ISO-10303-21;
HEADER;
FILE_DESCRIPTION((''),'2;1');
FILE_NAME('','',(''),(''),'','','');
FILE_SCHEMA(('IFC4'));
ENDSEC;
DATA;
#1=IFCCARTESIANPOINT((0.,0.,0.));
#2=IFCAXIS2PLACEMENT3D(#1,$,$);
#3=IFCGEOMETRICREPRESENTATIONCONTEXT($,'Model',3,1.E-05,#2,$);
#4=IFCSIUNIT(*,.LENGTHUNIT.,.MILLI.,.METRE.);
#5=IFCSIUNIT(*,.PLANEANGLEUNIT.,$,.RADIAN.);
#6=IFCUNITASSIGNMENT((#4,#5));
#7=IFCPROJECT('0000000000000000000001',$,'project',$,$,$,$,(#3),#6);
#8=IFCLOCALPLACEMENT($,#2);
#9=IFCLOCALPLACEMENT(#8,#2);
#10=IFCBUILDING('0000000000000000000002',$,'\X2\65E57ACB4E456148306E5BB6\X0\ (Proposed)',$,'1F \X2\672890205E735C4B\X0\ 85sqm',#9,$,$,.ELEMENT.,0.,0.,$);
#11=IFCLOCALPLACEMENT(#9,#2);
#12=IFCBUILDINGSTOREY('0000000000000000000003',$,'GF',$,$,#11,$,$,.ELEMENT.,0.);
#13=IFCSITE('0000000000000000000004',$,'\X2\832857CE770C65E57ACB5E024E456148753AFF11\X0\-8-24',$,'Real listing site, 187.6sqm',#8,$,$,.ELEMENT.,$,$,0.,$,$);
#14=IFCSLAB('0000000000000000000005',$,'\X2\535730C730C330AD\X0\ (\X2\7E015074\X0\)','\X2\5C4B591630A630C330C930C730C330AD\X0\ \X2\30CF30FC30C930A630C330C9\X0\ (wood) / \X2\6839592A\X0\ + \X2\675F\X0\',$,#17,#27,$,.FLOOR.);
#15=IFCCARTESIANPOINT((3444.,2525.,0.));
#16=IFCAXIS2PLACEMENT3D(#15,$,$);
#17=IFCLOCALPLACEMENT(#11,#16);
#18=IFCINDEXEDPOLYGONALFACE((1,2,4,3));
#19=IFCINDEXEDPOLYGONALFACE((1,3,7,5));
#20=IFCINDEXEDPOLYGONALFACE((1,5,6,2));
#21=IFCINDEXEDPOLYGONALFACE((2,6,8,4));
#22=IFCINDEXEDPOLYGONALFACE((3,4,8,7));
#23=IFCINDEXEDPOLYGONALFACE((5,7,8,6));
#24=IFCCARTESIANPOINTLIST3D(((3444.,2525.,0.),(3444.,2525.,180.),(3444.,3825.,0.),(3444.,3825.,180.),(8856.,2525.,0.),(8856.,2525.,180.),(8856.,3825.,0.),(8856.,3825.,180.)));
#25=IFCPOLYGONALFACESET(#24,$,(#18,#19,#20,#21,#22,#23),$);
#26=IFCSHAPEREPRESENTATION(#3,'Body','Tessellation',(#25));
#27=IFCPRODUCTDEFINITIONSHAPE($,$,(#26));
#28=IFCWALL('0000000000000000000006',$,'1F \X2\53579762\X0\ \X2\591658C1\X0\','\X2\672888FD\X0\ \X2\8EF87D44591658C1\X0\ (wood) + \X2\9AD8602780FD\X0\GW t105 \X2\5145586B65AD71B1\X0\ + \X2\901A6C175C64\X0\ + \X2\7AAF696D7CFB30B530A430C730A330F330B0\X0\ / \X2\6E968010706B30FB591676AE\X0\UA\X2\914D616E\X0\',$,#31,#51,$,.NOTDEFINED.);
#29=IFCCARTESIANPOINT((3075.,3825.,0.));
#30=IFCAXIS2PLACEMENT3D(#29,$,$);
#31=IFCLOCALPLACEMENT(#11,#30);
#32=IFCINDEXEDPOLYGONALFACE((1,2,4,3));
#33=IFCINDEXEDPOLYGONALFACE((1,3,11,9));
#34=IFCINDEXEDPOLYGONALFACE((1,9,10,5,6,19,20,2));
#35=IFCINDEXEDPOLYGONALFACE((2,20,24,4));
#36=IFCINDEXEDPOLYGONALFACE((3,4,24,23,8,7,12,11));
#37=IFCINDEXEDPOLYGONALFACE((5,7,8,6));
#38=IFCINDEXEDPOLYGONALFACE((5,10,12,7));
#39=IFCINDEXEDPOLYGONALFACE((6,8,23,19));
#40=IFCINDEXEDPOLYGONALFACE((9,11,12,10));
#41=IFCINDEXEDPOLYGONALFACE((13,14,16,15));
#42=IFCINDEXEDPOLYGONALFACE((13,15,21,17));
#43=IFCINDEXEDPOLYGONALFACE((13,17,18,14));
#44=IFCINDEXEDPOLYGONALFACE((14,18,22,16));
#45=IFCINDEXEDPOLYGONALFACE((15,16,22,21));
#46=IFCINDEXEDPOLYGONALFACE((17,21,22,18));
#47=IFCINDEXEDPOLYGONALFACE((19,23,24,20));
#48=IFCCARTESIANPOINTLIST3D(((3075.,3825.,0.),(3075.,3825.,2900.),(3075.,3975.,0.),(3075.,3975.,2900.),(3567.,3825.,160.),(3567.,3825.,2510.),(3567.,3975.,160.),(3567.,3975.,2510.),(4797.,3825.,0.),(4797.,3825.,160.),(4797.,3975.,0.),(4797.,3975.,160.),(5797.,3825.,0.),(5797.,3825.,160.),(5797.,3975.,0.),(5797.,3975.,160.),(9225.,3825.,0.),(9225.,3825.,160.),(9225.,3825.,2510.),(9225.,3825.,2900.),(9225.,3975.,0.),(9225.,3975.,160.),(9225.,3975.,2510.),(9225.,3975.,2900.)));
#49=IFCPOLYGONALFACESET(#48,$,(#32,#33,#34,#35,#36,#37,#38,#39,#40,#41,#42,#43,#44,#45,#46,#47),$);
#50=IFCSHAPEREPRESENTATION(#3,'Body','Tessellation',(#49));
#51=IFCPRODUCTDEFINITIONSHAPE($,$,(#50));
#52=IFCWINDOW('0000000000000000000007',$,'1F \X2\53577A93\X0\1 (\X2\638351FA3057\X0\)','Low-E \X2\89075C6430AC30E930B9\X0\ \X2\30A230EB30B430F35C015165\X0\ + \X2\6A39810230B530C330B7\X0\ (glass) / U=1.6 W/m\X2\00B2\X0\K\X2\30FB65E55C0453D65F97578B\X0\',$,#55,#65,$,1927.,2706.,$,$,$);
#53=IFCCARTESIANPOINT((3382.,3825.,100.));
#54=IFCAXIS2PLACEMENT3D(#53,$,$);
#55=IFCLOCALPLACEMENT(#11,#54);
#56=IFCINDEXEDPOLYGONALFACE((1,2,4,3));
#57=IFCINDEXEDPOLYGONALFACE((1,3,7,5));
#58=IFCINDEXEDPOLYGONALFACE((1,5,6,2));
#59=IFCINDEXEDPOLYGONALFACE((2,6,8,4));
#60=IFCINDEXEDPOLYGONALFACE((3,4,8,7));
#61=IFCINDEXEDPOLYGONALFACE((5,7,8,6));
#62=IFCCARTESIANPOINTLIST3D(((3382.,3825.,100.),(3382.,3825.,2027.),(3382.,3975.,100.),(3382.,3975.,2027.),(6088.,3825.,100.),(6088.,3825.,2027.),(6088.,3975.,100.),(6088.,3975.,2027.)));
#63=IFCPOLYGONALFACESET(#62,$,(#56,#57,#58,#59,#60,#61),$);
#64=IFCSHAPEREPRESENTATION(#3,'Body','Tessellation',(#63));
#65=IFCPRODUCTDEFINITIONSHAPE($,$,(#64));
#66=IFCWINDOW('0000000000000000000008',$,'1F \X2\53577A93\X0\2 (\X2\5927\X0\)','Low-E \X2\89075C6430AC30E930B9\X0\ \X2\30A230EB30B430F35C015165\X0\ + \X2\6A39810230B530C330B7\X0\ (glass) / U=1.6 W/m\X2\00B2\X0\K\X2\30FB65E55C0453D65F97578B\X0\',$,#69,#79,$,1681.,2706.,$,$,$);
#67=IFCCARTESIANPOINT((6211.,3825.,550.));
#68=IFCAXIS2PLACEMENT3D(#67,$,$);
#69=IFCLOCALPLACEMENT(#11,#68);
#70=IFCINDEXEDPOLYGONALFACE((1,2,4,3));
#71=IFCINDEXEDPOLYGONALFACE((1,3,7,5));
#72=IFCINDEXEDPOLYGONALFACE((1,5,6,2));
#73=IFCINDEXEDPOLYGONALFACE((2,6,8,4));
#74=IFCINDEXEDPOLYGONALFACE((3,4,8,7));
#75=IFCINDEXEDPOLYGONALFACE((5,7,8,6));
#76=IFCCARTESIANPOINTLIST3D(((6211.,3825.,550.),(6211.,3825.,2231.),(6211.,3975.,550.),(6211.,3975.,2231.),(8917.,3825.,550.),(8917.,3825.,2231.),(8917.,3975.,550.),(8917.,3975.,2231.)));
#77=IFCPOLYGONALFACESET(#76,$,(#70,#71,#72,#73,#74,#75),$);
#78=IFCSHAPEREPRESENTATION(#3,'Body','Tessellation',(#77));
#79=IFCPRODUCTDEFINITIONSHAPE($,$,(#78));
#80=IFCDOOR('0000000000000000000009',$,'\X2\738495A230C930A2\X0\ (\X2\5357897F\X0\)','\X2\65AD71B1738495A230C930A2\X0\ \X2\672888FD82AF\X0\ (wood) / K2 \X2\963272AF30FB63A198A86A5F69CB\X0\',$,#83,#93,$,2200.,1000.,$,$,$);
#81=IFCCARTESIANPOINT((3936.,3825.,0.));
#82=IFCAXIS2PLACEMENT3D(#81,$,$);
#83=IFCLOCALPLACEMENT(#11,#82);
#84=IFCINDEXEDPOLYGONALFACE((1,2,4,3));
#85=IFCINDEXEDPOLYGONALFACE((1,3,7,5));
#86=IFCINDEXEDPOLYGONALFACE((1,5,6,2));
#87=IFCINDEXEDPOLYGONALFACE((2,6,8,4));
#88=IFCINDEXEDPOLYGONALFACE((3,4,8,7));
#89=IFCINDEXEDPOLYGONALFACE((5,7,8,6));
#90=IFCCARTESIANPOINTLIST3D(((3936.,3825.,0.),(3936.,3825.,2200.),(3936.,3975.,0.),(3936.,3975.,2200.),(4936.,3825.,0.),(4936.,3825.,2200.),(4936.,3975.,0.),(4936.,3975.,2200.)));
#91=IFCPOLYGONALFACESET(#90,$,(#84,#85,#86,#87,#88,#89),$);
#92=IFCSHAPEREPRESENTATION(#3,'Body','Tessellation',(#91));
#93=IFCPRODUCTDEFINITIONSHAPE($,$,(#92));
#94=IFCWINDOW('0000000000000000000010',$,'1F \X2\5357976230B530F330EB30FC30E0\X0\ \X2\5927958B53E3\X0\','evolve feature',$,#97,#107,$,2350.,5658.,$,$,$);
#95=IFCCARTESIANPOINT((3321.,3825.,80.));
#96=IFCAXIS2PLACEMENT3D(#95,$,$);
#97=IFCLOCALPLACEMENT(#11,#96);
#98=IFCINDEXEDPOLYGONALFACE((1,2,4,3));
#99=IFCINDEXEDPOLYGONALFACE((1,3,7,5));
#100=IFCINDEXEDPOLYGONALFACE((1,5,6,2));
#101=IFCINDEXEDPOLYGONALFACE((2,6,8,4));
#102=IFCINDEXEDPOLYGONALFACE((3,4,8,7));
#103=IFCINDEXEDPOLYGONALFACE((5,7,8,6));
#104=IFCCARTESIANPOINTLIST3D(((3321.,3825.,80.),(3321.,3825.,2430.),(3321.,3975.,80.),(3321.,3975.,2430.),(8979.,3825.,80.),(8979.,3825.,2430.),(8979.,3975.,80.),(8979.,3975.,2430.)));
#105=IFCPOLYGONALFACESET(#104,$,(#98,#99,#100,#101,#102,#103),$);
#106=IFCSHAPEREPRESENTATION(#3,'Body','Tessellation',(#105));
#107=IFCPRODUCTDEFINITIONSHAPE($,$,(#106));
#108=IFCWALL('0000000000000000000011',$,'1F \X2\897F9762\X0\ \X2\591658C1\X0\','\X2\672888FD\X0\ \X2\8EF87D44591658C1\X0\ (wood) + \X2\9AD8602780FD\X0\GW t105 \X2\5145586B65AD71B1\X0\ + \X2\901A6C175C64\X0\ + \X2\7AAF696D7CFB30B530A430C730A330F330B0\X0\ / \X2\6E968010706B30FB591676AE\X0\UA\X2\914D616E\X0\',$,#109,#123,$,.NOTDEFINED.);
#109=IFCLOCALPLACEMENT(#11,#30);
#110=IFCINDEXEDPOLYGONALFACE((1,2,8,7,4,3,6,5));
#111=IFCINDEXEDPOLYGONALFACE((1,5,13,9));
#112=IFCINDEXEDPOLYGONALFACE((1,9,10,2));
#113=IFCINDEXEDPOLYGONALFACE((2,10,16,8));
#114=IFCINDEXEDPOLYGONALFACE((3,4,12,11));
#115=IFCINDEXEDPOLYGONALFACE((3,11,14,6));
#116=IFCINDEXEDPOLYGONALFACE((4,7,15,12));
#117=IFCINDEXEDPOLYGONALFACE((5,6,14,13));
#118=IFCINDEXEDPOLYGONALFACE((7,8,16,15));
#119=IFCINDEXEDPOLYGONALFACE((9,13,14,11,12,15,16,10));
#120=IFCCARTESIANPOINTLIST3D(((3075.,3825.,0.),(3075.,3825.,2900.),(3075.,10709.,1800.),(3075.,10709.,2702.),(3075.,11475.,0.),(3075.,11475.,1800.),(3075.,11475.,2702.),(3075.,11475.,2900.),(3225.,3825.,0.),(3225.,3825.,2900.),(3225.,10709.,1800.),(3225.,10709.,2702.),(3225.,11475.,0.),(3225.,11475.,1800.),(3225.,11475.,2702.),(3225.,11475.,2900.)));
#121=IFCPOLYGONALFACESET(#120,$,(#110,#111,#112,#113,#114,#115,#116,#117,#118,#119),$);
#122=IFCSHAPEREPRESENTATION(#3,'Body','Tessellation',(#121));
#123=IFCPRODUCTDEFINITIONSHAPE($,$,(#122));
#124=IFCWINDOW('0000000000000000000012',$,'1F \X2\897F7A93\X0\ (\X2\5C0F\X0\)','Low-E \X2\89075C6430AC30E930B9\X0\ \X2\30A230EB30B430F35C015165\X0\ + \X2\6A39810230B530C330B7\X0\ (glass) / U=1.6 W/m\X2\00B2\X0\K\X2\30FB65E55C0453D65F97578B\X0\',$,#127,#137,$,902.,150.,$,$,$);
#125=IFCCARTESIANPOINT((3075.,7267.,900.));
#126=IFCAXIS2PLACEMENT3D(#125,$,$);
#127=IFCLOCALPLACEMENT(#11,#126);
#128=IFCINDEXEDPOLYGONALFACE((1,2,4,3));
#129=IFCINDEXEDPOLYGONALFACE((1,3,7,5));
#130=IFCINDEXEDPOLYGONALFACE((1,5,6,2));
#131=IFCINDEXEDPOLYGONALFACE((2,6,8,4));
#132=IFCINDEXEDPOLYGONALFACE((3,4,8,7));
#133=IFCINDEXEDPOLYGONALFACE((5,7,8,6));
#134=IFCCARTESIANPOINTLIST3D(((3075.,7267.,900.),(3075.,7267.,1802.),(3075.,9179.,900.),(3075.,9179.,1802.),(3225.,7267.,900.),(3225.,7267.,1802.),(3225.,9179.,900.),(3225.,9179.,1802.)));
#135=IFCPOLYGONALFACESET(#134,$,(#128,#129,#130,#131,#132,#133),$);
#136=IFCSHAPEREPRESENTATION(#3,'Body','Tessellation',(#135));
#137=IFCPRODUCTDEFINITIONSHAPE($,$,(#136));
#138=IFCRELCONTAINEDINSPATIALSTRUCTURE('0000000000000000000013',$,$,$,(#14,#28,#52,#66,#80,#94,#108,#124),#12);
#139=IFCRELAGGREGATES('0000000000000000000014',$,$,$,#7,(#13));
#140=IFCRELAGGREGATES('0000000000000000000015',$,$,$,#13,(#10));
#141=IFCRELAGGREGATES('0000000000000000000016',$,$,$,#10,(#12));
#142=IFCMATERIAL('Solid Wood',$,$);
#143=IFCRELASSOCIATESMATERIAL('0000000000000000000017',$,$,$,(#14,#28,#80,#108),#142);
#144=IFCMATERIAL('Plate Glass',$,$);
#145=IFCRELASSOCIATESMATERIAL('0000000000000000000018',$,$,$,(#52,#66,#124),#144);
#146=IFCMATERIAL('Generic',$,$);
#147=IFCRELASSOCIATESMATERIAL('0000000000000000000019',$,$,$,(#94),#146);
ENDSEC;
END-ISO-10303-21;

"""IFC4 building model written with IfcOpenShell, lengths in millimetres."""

from ifc_helpers import new_model, si_unit, frame, frame_2d, origin, place, context, project, spatial, rectangle, extrude, material, element, fill, save


model = new_model("IFC4")

# Units and contexts
model_context = context("Model", 3, precision=1e-05, world=origin())
ifc_project = project(units=[si_unit("LENGTHUNIT", "METRE", prefix="MILLI"), si_unit("PLANEANGLEUNIT", "RADIAN")], contexts=[model_context])

# Site, building, storey
site_placement = place(None, origin())
site = spatial("IfcSite", under=ifc_project, at=site_placement, Name="茨城県日立市久慈町１-8-24", ObjectType="Real listing site, 187.6sqm", CompositionType="ELEMENT", RefElevation=0.0)
building_placement = place(site_placement, origin())
building = spatial("IfcBuilding", under=site, at=building_placement, Name="日立久慈の家 (Proposed)", ObjectType="1F 木造平屋 85sqm", CompositionType="ELEMENT", ElevationOfRefHeight=0.0, ElevationOfTerrain=0.0)
storey_placement = place(building_placement, origin())
storey = spatial("IfcBuildingStorey", under=building, at=storey_placement, Name="GF", CompositionType="ELEMENT", Elevation=0.0)

# Slab
ifc_material_1 = material(Name="Solid Wood")
slab_1_placement = place(storey_placement, frame((3444.0, 2525.0, 0.0)))
element("IfcSlab", 1, at=slab_1_placement, inside=storey, material=ifc_material_1, Name="南デッキ (縁側)", Description="屋外ウッドデッキ ハードウッド (wood) / 根太 + 束", PredefinedType="FLOOR", context=model_context, shape_type="SweptSolid", body=[
    extrude(rectangle(XDim=5412.0, YDim=1300.0, at=frame_2d((2706.0, 650.0))), frame((3444.0, 2525.0, 0.0)), (0.0, 0.0, 1.0), 180.0),
])
ifc_material_2 = material(Name="Generic")

# Wall, openings, windows, door
wall_1_placement = place(storey_placement, frame((3075.0, 3825.0, 0.0)))
wall_1 = element("IfcWall", 2, at=wall_1_placement, inside=storey, material=ifc_material_1, Name="1F 南面 外壁", Description="木製 軸組外壁 (wood) + 高性能GW t105 充填断熱 + 通気層 + 窯業系サイディング / 準耐火・外皮UA配慮", PredefinedType="NOTDEFINED", context=model_context, shape_type="SweptSolid", body=[
    extrude(rectangle(XDim=6150.0, YDim=150.0, at=frame_2d((3075.0, 75.0))), frame((3075.0, 3825.0, 0.0)), (0.0, 0.0, 1.0), 2900.0),
])
opening_1_placement = place(storey_placement, frame((3382.0, 3825.0, 100.0)))
opening_1 = element("IfcOpeningElement", 3, at=opening_1_placement, cuts=wall_1, PredefinedType="NOTDEFINED", context=model_context, shape_type="SweptSolid", body=[
    extrude(rectangle(XDim=2706.0, YDim=150.0, at=frame_2d((1353.0, 75.0))), frame((3382.0, 3825.0, 100.0)), (0.0, 0.0, 1.0), 1927.0),
])
opening_2_placement = place(storey_placement, frame((6211.0, 3825.0, 550.0)))
opening_2 = element("IfcOpeningElement", 4, at=opening_2_placement, cuts=wall_1, PredefinedType="NOTDEFINED", context=model_context, shape_type="SweptSolid", body=[
    extrude(rectangle(XDim=2706.0, YDim=150.0, at=frame_2d((1353.0, 75.0))), frame((6211.0, 3825.0, 550.0)), (0.0, 0.0, 1.0), 1681.0),
])
opening_3_placement = place(storey_placement, frame((3936.0, 3825.0, 0.0)))
opening_3 = element("IfcOpeningElement", 5, at=opening_3_placement, cuts=wall_1, PredefinedType="NOTDEFINED", context=model_context, shape_type="SweptSolid", body=[
    extrude(rectangle(XDim=1000.0, YDim=150.0, at=frame_2d((500.0, 75.0))), frame((3936.0, 3825.0, 0.0)), (0.0, 0.0, 1.0), 2200.0),
])
opening_4_placement = place(storey_placement, frame((3321.0, 3825.0, 80.0)))
opening_4 = element("IfcOpeningElement", 6, at=opening_4_placement, cuts=wall_1, PredefinedType="NOTDEFINED", context=model_context, shape_type="SweptSolid", body=[
    extrude(rectangle(XDim=5658.0, YDim=150.0, at=frame_2d((2829.0, 75.0))), frame((3321.0, 3825.0, 80.0)), (0.0, 0.0, 1.0), 2350.0),
])
ifc_material_3 = material(Name="Plate Glass")
window_1_placement = place(storey_placement, frame((3382.0, 3825.0, 100.0)))
window_1 = element("IfcWindow", 7, at=window_1_placement, inside=storey, material=ifc_material_3, Name="1F 南窓1 (掃出し)", Description="Low-E 複層ガラス アルゴン封入 + 樹脂サッシ (glass) / U=1.6 W/m²K・日射取得型", OverallHeight=1927.0, OverallWidth=2706.0, context=model_context, shape_type="SweptSolid", body=[
    extrude(rectangle(XDim=2706.0, YDim=150.0, at=frame_2d((1353.0, 75.0))), frame((3382.0, 3825.0, 100.0)), (0.0, 0.0, 1.0), 1927.0),
])
fill(opening_1, window_1)
window_2_placement = place(storey_placement, frame((6211.0, 3825.0, 550.0)))
window_2 = element("IfcWindow", 8, at=window_2_placement, inside=storey, material=ifc_material_3, Name="1F 南窓2 (大)", Description="Low-E 複層ガラス アルゴン封入 + 樹脂サッシ (glass) / U=1.6 W/m²K・日射取得型", OverallHeight=1681.0, OverallWidth=2706.0, context=model_context, shape_type="SweptSolid", body=[
    extrude(rectangle(XDim=2706.0, YDim=150.0, at=frame_2d((1353.0, 75.0))), frame((6211.0, 3825.0, 550.0)), (0.0, 0.0, 1.0), 1681.0),
])
fill(opening_2, window_2)
door_placement = place(storey_placement, frame((3936.0, 3825.0, 0.0)))
door = element("IfcDoor", 9, at=door_placement, inside=storey, material=ifc_material_1, Name="玄関ドア (南西)", Description="断熱玄関ドア 木製芯 (wood) / K2 防犯・採風機構", OverallHeight=2200.0, OverallWidth=1000.0, context=model_context, shape_type="SweptSolid", body=[
    extrude(rectangle(XDim=1000.0, YDim=150.0, at=frame_2d((500.0, 75.0))), frame((3936.0, 3825.0, 0.0)), (0.0, 0.0, 1.0), 2200.0),
])
fill(opening_3, door)
window_3_placement = place(storey_placement, frame((3321.0, 3825.0, 80.0)))
window_3 = element("IfcWindow", 10, at=window_3_placement, inside=storey, material=ifc_material_2, Name="1F 南面サンルーム 大開口", Description="evolve feature", OverallHeight=2350.0, OverallWidth=5658.0, context=model_context, shape_type="SweptSolid", body=[
    extrude(rectangle(XDim=5658.0, YDim=150.0, at=frame_2d((2829.0, 75.0))), frame((3321.0, 3825.0, 80.0)), (0.0, 0.0, 1.0), 2350.0),
])
fill(opening_4, window_3)

# Wall, opening, window
wall_2_placement = place(storey_placement, frame((3075.0, 3825.0, 0.0)))
wall_2 = element("IfcWall", 11, at=wall_2_placement, inside=storey, material=ifc_material_1, Name="1F 西面 外壁", Description="木製 軸組外壁 (wood) + 高性能GW t105 充填断熱 + 通気層 + 窯業系サイディング / 準耐火・外皮UA配慮", PredefinedType="NOTDEFINED", context=model_context, shape_type="SweptSolid", body=[
    extrude(rectangle(XDim=150.0, YDim=7650.0, at=frame_2d((75.0, 3825.0))), frame((3075.0, 3825.0, 0.0)), (0.0, 0.0, 1.0), 2900.0),
])
opening_5_placement = place(storey_placement, frame((3075.0, 7267.0, 900.0)))
opening_5 = element("IfcOpeningElement", 12, at=opening_5_placement, cuts=wall_2, PredefinedType="NOTDEFINED", context=model_context, shape_type="SweptSolid", body=[
    extrude(rectangle(XDim=150.0, YDim=1912.0, at=frame_2d((75.0, 956.0))), frame((3075.0, 7267.0, 900.0)), (0.0, 0.0, 1.0), 902.0),
])
window_4_placement = place(storey_placement, frame((3075.0, 7267.0, 900.0)))
window_4 = element("IfcWindow", 13, at=window_4_placement, inside=storey, material=ifc_material_3, Name="1F 西窓 (小)", Description="Low-E 複層ガラス アルゴン封入 + 樹脂サッシ (glass) / U=1.6 W/m²K・日射取得型", OverallHeight=902.0, OverallWidth=150.0, context=model_context, shape_type="SweptSolid", body=[
    extrude(rectangle(XDim=150.0, YDim=1912.0, at=frame_2d((75.0, 956.0))), frame((3075.0, 7267.0, 900.0)), (0.0, 0.0, 1.0), 902.0),
])
fill(opening_5, window_4)

save(model, "model.ifc")
